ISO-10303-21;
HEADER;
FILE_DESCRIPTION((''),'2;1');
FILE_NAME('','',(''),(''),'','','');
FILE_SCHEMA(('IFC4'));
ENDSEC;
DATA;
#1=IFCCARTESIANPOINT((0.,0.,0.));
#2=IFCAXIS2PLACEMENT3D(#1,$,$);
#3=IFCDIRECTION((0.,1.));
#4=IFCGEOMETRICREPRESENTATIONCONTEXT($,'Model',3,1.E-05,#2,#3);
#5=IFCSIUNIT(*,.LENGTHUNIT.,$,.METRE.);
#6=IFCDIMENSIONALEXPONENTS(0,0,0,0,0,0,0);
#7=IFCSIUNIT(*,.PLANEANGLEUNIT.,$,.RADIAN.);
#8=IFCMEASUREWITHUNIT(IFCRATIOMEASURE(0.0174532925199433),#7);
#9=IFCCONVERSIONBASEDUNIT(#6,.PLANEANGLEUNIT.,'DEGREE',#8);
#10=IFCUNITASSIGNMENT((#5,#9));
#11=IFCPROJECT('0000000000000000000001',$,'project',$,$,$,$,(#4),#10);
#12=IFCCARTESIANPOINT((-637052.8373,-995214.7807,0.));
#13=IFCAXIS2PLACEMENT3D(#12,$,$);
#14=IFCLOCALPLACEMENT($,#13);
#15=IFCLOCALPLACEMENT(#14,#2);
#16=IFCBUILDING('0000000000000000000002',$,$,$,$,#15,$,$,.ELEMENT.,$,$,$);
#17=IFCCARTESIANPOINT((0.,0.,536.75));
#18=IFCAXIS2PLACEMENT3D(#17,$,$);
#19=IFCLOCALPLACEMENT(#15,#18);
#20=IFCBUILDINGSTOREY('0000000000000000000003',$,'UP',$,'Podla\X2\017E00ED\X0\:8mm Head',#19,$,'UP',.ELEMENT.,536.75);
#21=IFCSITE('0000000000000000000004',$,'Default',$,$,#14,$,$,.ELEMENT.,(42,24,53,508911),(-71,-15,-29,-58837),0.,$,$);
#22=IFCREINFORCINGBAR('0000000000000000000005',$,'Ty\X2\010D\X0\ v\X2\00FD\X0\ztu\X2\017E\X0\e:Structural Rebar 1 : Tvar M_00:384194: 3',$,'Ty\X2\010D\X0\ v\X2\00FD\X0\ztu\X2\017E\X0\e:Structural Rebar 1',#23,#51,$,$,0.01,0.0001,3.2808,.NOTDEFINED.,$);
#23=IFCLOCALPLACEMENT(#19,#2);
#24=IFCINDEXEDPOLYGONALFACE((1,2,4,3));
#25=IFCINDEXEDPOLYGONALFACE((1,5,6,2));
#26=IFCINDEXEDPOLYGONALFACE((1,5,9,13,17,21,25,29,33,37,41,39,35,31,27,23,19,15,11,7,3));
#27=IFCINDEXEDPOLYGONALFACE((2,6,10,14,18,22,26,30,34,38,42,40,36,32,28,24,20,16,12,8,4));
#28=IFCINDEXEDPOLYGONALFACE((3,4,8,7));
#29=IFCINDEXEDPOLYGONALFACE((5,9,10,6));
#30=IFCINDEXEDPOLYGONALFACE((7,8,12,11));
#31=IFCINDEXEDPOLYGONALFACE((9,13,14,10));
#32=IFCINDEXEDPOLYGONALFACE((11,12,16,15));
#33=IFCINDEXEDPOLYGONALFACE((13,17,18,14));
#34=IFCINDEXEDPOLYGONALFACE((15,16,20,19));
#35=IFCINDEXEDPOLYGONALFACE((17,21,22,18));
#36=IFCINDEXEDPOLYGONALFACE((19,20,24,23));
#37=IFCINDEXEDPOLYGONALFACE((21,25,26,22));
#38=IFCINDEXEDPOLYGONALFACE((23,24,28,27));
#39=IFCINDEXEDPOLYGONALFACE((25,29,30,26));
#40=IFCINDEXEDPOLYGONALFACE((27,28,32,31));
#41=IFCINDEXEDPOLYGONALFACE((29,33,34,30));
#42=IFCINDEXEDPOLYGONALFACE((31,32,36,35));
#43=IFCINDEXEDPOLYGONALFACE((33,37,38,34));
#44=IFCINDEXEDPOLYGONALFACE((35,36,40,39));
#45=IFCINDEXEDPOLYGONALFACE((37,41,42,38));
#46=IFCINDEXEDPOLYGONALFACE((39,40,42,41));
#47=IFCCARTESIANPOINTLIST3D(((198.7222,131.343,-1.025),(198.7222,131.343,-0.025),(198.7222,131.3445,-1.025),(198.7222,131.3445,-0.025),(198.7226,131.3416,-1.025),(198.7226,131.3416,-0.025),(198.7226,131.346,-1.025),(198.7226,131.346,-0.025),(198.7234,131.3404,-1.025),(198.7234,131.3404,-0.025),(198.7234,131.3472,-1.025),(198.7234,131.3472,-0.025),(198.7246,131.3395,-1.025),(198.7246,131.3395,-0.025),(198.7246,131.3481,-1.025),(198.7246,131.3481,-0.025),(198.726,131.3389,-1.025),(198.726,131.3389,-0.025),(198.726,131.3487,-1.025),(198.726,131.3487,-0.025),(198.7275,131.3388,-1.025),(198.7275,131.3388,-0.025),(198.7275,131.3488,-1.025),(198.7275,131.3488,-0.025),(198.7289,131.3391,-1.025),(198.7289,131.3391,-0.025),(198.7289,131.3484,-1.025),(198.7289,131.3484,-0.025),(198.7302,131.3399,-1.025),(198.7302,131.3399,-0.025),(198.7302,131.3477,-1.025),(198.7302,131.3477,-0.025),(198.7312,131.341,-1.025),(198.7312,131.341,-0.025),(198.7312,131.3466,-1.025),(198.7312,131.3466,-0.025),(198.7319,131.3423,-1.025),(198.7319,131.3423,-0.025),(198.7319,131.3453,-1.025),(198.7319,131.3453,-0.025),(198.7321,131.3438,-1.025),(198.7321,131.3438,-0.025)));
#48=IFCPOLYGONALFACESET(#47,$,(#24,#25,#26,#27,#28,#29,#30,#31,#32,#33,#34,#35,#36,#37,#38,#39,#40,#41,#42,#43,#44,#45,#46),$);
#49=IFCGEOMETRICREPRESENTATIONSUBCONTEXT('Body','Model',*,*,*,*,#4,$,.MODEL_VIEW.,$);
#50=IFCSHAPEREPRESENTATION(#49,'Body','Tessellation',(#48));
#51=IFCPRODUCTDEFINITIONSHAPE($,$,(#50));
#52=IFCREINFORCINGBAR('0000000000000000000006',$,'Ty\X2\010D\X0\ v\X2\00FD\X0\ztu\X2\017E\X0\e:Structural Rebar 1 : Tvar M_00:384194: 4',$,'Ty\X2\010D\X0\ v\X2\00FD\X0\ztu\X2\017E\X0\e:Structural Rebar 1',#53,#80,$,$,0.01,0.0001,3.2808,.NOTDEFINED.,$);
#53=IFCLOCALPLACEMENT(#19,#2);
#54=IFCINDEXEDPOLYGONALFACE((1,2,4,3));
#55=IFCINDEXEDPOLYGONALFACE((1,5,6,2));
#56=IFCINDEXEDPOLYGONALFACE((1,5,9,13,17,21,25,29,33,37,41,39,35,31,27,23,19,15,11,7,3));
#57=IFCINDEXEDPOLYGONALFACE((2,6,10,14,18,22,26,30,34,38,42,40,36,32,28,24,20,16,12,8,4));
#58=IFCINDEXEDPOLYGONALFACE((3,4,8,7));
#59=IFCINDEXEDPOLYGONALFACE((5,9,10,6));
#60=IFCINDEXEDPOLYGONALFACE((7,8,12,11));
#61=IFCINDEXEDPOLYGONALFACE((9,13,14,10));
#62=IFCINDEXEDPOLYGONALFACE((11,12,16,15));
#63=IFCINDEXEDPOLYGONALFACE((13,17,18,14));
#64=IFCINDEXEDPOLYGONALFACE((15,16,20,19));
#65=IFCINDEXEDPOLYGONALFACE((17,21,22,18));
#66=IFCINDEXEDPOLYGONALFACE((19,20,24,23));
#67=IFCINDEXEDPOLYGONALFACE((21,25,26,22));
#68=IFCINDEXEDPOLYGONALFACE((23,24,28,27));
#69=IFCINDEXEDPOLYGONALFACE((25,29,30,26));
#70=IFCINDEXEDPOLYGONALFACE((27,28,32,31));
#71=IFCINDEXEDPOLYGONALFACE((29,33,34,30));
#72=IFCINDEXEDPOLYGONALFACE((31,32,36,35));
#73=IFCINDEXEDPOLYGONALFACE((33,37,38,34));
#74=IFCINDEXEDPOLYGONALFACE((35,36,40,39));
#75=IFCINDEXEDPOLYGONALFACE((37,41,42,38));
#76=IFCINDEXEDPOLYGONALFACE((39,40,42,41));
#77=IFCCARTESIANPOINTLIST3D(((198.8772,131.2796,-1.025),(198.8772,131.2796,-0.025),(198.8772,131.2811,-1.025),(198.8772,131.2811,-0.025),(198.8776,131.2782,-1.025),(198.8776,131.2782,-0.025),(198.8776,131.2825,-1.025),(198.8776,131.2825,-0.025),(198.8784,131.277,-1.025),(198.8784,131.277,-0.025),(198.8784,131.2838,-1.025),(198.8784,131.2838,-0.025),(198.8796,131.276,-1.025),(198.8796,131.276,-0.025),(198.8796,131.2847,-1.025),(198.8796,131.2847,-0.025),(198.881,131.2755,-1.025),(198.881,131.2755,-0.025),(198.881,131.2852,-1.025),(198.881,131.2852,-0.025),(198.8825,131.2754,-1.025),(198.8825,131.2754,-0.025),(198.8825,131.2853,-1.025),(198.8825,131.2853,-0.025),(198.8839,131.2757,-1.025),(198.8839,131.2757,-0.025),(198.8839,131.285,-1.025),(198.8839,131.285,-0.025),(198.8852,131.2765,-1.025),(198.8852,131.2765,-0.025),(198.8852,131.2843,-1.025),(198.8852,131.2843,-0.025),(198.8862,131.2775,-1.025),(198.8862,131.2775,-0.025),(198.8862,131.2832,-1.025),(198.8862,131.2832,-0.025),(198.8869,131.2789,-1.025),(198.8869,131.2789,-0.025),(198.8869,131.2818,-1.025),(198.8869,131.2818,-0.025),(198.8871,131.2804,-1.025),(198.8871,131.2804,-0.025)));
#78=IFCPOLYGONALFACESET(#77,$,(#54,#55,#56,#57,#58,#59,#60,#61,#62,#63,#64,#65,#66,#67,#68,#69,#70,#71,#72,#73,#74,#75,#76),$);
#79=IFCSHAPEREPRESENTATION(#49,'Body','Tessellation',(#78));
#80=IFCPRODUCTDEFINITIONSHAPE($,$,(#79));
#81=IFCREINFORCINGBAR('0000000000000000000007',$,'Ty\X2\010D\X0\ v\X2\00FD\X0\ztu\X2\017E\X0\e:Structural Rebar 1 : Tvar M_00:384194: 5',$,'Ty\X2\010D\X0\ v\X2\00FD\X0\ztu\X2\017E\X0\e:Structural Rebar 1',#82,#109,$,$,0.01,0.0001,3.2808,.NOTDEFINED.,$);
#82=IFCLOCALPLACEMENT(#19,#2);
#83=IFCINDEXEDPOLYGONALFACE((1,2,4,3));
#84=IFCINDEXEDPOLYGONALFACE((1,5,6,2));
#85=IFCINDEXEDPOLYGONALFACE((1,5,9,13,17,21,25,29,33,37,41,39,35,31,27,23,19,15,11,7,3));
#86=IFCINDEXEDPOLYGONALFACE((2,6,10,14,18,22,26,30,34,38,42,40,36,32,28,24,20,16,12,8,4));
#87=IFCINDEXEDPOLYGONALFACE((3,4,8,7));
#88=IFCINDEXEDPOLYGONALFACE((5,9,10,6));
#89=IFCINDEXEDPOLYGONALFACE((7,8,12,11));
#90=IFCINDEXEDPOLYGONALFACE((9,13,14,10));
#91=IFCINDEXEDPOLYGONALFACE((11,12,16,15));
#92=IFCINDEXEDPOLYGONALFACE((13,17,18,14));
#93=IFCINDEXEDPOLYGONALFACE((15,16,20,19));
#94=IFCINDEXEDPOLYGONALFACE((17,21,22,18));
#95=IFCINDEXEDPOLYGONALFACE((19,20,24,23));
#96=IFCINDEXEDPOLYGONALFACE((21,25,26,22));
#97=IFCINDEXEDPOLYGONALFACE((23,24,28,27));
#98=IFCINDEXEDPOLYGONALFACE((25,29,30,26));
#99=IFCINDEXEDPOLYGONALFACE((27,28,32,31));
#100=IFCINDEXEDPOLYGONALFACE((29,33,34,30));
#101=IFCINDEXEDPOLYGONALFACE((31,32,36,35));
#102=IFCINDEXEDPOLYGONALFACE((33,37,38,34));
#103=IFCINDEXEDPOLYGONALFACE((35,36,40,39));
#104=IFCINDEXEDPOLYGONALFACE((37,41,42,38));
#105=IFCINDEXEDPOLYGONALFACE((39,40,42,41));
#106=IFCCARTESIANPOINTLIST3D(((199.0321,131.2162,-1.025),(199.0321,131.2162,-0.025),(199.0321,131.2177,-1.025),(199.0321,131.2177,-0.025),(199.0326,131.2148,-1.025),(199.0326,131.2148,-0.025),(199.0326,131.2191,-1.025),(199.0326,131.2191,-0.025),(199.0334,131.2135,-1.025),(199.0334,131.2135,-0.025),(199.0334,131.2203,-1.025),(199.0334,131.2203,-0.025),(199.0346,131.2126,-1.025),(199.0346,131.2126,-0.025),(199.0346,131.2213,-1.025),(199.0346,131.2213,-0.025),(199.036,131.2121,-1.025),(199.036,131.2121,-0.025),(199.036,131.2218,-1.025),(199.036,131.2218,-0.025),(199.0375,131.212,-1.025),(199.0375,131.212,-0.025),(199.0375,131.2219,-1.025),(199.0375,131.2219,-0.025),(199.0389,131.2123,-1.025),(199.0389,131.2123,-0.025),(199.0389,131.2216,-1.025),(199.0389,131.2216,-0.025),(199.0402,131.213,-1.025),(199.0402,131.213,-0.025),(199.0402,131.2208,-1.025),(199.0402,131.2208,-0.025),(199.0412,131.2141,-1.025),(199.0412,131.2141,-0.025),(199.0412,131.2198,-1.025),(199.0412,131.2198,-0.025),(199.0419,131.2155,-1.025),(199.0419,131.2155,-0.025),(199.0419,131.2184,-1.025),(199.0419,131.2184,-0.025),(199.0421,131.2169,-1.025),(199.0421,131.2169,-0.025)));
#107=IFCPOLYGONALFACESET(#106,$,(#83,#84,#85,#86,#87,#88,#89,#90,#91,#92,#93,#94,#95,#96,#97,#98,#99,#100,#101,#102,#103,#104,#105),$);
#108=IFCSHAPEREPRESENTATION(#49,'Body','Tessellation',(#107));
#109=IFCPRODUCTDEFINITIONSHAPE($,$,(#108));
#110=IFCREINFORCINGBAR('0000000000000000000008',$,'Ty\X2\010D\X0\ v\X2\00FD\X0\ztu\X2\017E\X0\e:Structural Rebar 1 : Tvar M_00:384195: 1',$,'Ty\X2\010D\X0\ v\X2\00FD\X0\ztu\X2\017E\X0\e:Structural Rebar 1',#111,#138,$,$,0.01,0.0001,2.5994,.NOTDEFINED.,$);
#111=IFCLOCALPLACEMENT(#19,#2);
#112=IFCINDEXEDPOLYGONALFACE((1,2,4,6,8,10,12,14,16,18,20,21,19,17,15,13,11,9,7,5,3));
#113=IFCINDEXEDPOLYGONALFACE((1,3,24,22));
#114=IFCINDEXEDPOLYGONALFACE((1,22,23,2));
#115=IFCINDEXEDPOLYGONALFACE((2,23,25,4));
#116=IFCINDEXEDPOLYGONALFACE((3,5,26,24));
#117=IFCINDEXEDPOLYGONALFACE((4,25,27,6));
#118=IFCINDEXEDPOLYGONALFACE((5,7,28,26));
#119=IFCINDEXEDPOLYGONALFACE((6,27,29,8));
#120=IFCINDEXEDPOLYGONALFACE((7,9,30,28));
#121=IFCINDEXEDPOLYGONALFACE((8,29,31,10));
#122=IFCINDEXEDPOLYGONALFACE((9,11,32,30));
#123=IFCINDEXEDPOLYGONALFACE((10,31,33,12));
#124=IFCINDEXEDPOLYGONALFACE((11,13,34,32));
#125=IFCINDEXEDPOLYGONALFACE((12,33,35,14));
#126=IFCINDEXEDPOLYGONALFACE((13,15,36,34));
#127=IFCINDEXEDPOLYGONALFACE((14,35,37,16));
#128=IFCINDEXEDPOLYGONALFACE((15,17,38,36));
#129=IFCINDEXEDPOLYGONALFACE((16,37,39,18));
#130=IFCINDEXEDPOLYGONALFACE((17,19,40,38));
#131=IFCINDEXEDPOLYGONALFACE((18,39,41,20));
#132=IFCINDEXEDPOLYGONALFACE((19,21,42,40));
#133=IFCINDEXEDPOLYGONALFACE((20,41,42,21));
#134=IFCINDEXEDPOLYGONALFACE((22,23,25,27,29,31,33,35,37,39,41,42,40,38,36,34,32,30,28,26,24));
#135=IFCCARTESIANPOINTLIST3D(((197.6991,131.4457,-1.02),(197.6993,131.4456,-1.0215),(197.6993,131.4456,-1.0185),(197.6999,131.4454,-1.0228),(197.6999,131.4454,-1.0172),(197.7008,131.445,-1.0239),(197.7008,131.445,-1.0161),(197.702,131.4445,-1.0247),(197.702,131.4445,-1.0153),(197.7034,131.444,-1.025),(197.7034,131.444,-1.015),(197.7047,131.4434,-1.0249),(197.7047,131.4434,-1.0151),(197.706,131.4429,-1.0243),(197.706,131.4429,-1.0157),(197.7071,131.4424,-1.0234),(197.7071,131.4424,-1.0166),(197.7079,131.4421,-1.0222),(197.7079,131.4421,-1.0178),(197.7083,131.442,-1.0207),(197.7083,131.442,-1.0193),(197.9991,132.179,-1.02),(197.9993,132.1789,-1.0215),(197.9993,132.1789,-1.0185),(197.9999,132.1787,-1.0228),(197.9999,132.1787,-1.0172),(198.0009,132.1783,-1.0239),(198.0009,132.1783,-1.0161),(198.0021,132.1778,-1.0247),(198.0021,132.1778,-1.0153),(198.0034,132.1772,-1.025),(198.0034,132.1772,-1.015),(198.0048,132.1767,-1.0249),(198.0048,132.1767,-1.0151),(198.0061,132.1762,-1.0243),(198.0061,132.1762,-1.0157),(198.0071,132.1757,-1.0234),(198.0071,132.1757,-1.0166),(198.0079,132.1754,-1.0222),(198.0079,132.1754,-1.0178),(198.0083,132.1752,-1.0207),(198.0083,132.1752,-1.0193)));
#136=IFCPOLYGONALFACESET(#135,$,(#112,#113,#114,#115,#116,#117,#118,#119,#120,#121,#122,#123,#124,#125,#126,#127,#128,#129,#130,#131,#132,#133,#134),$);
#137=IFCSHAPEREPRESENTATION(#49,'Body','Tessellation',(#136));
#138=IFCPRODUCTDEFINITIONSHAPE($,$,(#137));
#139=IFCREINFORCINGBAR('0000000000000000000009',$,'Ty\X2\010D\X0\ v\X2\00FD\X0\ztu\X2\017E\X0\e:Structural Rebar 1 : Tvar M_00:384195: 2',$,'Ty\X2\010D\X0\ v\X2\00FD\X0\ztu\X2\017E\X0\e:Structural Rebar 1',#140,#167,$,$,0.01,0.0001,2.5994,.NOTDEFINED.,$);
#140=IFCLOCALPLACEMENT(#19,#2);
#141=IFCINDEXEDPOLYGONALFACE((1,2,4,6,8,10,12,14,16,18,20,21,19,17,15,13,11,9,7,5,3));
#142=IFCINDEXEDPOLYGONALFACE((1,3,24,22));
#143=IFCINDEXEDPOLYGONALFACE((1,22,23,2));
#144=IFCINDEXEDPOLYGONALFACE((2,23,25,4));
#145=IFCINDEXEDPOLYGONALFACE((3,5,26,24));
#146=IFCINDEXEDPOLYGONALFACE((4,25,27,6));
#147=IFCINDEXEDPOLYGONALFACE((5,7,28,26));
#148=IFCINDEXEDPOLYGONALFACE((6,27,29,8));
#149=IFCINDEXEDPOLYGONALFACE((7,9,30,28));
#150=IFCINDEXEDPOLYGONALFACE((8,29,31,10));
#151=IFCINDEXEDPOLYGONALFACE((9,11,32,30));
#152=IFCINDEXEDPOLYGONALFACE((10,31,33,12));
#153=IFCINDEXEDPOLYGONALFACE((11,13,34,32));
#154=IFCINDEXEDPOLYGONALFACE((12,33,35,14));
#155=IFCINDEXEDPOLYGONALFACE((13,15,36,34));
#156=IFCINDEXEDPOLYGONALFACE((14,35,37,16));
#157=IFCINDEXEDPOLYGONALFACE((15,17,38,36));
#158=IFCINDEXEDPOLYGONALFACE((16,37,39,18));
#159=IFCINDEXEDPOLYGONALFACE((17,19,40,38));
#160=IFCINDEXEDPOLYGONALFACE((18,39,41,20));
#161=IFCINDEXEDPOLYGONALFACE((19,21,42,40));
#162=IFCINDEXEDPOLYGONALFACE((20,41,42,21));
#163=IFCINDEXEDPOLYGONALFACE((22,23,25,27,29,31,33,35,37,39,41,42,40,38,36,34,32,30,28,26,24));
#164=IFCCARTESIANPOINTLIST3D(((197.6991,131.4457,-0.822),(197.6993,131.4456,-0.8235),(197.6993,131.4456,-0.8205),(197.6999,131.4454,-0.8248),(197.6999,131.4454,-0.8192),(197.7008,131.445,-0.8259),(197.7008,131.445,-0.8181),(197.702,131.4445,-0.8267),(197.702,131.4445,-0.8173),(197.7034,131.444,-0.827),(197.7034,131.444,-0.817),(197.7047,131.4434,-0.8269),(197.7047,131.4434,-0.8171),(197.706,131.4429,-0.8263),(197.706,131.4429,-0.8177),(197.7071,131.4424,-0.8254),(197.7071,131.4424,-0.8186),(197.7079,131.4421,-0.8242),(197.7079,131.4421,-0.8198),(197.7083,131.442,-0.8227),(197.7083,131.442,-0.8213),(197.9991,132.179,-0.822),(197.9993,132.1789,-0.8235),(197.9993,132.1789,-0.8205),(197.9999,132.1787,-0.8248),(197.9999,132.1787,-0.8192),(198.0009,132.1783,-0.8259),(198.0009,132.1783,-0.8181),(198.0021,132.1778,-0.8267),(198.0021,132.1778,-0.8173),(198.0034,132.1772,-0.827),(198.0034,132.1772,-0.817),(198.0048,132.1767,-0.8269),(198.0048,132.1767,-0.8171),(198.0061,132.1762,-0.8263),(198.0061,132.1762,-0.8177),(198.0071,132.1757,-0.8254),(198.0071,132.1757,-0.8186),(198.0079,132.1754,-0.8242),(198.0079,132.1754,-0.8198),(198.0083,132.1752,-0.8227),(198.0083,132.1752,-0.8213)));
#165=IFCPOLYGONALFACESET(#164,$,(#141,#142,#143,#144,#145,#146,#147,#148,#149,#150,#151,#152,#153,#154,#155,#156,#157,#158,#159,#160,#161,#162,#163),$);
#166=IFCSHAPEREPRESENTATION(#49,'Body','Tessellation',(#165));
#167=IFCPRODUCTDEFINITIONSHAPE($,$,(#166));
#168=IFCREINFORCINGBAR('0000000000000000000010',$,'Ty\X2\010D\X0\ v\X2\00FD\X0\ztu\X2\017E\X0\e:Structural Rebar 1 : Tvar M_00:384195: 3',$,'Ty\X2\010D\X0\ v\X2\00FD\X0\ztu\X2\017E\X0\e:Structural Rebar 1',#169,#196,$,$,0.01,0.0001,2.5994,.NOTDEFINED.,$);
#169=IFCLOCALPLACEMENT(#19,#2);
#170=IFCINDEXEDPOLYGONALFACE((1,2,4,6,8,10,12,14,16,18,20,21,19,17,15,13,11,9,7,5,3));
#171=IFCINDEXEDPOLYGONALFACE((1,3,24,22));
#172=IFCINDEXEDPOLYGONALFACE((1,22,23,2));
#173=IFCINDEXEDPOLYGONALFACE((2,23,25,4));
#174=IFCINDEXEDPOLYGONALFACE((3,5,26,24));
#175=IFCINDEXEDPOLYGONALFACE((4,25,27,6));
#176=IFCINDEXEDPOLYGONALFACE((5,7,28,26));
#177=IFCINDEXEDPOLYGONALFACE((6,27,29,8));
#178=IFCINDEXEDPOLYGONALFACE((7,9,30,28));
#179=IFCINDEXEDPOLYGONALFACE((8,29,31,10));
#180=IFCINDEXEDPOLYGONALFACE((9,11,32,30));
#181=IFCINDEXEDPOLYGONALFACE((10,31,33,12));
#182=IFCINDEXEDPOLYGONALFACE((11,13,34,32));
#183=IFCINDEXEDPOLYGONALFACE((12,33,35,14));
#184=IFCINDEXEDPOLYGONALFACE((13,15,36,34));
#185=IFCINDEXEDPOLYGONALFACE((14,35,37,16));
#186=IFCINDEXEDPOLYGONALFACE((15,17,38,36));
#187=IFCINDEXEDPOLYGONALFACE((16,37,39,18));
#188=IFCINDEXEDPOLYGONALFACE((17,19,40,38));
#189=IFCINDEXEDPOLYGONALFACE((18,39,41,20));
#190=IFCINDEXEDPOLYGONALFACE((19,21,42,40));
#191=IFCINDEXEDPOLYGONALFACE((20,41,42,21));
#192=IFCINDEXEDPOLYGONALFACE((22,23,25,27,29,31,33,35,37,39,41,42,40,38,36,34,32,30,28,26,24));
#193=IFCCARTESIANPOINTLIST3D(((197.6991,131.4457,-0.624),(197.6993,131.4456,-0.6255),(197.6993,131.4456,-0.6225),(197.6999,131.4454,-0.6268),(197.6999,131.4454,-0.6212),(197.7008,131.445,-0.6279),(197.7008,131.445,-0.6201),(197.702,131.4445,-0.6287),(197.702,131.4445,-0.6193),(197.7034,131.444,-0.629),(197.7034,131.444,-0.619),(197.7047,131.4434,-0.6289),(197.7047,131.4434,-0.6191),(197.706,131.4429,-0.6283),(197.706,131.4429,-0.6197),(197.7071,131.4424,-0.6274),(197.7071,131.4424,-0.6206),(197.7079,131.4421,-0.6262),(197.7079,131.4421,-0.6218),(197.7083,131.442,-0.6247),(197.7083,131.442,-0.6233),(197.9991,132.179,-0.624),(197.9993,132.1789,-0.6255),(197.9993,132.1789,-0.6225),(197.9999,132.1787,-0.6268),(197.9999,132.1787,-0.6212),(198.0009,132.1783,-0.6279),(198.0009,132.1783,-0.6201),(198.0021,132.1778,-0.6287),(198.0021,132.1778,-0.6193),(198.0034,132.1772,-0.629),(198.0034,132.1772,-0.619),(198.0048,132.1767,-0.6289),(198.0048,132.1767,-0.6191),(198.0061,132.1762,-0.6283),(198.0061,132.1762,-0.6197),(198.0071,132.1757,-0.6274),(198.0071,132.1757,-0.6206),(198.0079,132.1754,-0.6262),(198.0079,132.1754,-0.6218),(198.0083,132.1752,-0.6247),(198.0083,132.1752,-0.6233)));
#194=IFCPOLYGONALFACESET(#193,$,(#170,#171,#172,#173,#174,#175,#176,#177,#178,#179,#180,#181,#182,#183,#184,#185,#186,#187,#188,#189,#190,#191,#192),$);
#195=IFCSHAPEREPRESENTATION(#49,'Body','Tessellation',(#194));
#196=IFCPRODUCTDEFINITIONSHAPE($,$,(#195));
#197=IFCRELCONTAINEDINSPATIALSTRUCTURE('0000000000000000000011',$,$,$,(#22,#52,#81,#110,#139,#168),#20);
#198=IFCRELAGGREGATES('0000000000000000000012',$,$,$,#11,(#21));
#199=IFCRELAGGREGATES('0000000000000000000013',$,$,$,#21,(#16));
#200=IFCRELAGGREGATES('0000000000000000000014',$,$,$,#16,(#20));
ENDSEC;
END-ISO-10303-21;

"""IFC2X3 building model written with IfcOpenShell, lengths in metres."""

from ifc_helpers import new_model, entity, si_unit, converted_unit, direction, frame, origin, place, context, subcontext, project, spatial, element, save


model = new_model("IFC2X3")

# Units and contexts
model_context = context("Model", 3, precision=1e-05, world=origin(), true_north=direction((0.0, 1.0)))
body_context = subcontext(model_context, "Body", "Model", "MODEL_VIEW")
ifc_project = project(units=[si_unit("LENGTHUNIT", "METRE"), converted_unit("PLANEANGLEUNIT", "DEGREE", entity("IfcRatioMeasure", 0.0174532925199433), si_unit("PLANEANGLEUNIT", "RADIAN"), dimensions=[0, 0, 0, 0, 0, 0, 0])], contexts=[model_context])

# Site, building, storey
site_placement = place(None, frame((-637052.8373, -995214.7807, 0.0)))
site = spatial("IfcSite", under=ifc_project, at=site_placement, Name="Default", CompositionType="ELEMENT", RefLatitude=(42, 24, 53, 508911), RefLongitude=(-71, -15, -29, -58837), RefElevation=0.0)
building_placement = place(site_placement, origin())
building = spatial("IfcBuilding", under=site, at=building_placement, CompositionType="ELEMENT")
storey_placement = place(building_placement, frame((0.0, 0.0, 536.75)))
storey = spatial("IfcBuildingStorey", under=building, at=storey_placement, Name="UP", ObjectType="Podlaží:8mm Head", LongName="UP", CompositionType="ELEMENT", Elevation=536.75)

# Reinforcing bars
reinforcing_bar_1_placement = place(storey_placement, origin())
element("IfcReinforcingBar", 1, at=reinforcing_bar_1_placement, inside=storey, Name="Tyč výztuže:Structural Rebar 1 : Tvar M_00:384194: 3", ObjectType="Tyč výztuže:Structural Rebar 1", BarLength=3.2808, BarRole="NOTDEFINED", CrossSectionArea=0.0001, NominalDiameter=0.01, context=body_context, shape_type="AdvancedSweptSolid", body=[
    entity("IfcSweptDiskSolid", entity("IfcCompositeCurve", [entity("IfcCompositeCurveSegment", "CONTINUOUS", True, entity("IfcPolyline", [entity("IfcCartesianPoint", [-198.7271, -131.3438, 0.025]), entity("IfcCartesianPoint", [-198.7271, -131.3438, 1.025])]))], False), 0.005, None, 0.0, 1.0),
])
reinforcing_bar_2_placement = place(storey_placement, origin())
element("IfcReinforcingBar", 2, at=reinforcing_bar_2_placement, inside=storey, Name="Tyč výztuže:Structural Rebar 1 : Tvar M_00:384194: 4", ObjectType="Tyč výztuže:Structural Rebar 1", BarLength=3.2808, BarRole="NOTDEFINED", CrossSectionArea=0.0001, NominalDiameter=0.01, context=body_context, shape_type="AdvancedSweptSolid", body=[
    entity("IfcSweptDiskSolid", entity("IfcCompositeCurve", [entity("IfcCompositeCurveSegment", "CONTINUOUS", True, entity("IfcPolyline", [entity("IfcCartesianPoint", [-198.8821, -131.2804, 0.025]), entity("IfcCartesianPoint", [-198.8821, -131.2804, 1.025])]))], False), 0.005, None, 0.0, 1.0),
])
reinforcing_bar_3_placement = place(storey_placement, origin())
element("IfcReinforcingBar", 3, at=reinforcing_bar_3_placement, inside=storey, Name="Tyč výztuže:Structural Rebar 1 : Tvar M_00:384194: 5", ObjectType="Tyč výztuže:Structural Rebar 1", BarLength=3.2808, BarRole="NOTDEFINED", CrossSectionArea=0.0001, NominalDiameter=0.01, context=body_context, shape_type="AdvancedSweptSolid", body=[
    entity("IfcSweptDiskSolid", entity("IfcCompositeCurve", [entity("IfcCompositeCurveSegment", "CONTINUOUS", True, entity("IfcPolyline", [entity("IfcCartesianPoint", [-199.0371, -131.2169, 0.025]), entity("IfcCartesianPoint", [-199.0371, -131.2169, 1.025])]))], False), 0.005, None, 0.0, 1.0),
])
reinforcing_bar_4_placement = place(storey_placement, origin())
element("IfcReinforcingBar", 4, at=reinforcing_bar_4_placement, inside=storey, Name="Tyč výztuže:Structural Rebar 1 : Tvar M_00:384195: 1", ObjectType="Tyč výztuže:Structural Rebar 1", BarLength=2.5994, BarRole="NOTDEFINED", CrossSectionArea=0.0001, NominalDiameter=0.01, context=body_context, shape_type="AdvancedSweptSolid", body=[
    entity("IfcSweptDiskSolid", entity("IfcCompositeCurve", [entity("IfcCompositeCurveSegment", "CONTINUOUS", True, entity("IfcPolyline", [entity("IfcCartesianPoint", [-197.7037, -131.4438, 1.02]), entity("IfcCartesianPoint", [-198.0038, -132.1771, 1.02])]))], False), 0.005, None, 0.0, 1.0),
])
reinforcing_bar_5_placement = place(storey_placement, origin())
element("IfcReinforcingBar", 5, at=reinforcing_bar_5_placement, inside=storey, Name="Tyč výztuže:Structural Rebar 1 : Tvar M_00:384195: 2", ObjectType="Tyč výztuže:Structural Rebar 1", BarLength=2.5994, BarRole="NOTDEFINED", CrossSectionArea=0.0001, NominalDiameter=0.01, context=body_context, shape_type="AdvancedSweptSolid", body=[
    entity("IfcSweptDiskSolid", entity("IfcCompositeCurve", [entity("IfcCompositeCurveSegment", "CONTINUOUS", True, entity("IfcPolyline", [entity("IfcCartesianPoint", [-197.7037, -131.4438, 0.822]), entity("IfcCartesianPoint", [-198.0038, -132.1771, 0.822])]))], False), 0.005, None, 0.0, 1.0),
])
reinforcing_bar_6_placement = place(storey_placement, origin())
element("IfcReinforcingBar", 6, at=reinforcing_bar_6_placement, inside=storey, Name="Tyč výztuže:Structural Rebar 1 : Tvar M_00:384195: 3", ObjectType="Tyč výztuže:Structural Rebar 1", BarLength=2.5994, BarRole="NOTDEFINED", CrossSectionArea=0.0001, NominalDiameter=0.01, context=body_context, shape_type="AdvancedSweptSolid", body=[
    entity("IfcSweptDiskSolid", entity("IfcCompositeCurve", [entity("IfcCompositeCurveSegment", "CONTINUOUS", True, entity("IfcPolyline", [entity("IfcCartesianPoint", [-197.7037, -131.4438, 0.624]), entity("IfcCartesianPoint", [-198.0038, -132.1771, 0.624])]))], False), 0.005, None, 0.0, 1.0),
])

save(model, "model.ifc")
